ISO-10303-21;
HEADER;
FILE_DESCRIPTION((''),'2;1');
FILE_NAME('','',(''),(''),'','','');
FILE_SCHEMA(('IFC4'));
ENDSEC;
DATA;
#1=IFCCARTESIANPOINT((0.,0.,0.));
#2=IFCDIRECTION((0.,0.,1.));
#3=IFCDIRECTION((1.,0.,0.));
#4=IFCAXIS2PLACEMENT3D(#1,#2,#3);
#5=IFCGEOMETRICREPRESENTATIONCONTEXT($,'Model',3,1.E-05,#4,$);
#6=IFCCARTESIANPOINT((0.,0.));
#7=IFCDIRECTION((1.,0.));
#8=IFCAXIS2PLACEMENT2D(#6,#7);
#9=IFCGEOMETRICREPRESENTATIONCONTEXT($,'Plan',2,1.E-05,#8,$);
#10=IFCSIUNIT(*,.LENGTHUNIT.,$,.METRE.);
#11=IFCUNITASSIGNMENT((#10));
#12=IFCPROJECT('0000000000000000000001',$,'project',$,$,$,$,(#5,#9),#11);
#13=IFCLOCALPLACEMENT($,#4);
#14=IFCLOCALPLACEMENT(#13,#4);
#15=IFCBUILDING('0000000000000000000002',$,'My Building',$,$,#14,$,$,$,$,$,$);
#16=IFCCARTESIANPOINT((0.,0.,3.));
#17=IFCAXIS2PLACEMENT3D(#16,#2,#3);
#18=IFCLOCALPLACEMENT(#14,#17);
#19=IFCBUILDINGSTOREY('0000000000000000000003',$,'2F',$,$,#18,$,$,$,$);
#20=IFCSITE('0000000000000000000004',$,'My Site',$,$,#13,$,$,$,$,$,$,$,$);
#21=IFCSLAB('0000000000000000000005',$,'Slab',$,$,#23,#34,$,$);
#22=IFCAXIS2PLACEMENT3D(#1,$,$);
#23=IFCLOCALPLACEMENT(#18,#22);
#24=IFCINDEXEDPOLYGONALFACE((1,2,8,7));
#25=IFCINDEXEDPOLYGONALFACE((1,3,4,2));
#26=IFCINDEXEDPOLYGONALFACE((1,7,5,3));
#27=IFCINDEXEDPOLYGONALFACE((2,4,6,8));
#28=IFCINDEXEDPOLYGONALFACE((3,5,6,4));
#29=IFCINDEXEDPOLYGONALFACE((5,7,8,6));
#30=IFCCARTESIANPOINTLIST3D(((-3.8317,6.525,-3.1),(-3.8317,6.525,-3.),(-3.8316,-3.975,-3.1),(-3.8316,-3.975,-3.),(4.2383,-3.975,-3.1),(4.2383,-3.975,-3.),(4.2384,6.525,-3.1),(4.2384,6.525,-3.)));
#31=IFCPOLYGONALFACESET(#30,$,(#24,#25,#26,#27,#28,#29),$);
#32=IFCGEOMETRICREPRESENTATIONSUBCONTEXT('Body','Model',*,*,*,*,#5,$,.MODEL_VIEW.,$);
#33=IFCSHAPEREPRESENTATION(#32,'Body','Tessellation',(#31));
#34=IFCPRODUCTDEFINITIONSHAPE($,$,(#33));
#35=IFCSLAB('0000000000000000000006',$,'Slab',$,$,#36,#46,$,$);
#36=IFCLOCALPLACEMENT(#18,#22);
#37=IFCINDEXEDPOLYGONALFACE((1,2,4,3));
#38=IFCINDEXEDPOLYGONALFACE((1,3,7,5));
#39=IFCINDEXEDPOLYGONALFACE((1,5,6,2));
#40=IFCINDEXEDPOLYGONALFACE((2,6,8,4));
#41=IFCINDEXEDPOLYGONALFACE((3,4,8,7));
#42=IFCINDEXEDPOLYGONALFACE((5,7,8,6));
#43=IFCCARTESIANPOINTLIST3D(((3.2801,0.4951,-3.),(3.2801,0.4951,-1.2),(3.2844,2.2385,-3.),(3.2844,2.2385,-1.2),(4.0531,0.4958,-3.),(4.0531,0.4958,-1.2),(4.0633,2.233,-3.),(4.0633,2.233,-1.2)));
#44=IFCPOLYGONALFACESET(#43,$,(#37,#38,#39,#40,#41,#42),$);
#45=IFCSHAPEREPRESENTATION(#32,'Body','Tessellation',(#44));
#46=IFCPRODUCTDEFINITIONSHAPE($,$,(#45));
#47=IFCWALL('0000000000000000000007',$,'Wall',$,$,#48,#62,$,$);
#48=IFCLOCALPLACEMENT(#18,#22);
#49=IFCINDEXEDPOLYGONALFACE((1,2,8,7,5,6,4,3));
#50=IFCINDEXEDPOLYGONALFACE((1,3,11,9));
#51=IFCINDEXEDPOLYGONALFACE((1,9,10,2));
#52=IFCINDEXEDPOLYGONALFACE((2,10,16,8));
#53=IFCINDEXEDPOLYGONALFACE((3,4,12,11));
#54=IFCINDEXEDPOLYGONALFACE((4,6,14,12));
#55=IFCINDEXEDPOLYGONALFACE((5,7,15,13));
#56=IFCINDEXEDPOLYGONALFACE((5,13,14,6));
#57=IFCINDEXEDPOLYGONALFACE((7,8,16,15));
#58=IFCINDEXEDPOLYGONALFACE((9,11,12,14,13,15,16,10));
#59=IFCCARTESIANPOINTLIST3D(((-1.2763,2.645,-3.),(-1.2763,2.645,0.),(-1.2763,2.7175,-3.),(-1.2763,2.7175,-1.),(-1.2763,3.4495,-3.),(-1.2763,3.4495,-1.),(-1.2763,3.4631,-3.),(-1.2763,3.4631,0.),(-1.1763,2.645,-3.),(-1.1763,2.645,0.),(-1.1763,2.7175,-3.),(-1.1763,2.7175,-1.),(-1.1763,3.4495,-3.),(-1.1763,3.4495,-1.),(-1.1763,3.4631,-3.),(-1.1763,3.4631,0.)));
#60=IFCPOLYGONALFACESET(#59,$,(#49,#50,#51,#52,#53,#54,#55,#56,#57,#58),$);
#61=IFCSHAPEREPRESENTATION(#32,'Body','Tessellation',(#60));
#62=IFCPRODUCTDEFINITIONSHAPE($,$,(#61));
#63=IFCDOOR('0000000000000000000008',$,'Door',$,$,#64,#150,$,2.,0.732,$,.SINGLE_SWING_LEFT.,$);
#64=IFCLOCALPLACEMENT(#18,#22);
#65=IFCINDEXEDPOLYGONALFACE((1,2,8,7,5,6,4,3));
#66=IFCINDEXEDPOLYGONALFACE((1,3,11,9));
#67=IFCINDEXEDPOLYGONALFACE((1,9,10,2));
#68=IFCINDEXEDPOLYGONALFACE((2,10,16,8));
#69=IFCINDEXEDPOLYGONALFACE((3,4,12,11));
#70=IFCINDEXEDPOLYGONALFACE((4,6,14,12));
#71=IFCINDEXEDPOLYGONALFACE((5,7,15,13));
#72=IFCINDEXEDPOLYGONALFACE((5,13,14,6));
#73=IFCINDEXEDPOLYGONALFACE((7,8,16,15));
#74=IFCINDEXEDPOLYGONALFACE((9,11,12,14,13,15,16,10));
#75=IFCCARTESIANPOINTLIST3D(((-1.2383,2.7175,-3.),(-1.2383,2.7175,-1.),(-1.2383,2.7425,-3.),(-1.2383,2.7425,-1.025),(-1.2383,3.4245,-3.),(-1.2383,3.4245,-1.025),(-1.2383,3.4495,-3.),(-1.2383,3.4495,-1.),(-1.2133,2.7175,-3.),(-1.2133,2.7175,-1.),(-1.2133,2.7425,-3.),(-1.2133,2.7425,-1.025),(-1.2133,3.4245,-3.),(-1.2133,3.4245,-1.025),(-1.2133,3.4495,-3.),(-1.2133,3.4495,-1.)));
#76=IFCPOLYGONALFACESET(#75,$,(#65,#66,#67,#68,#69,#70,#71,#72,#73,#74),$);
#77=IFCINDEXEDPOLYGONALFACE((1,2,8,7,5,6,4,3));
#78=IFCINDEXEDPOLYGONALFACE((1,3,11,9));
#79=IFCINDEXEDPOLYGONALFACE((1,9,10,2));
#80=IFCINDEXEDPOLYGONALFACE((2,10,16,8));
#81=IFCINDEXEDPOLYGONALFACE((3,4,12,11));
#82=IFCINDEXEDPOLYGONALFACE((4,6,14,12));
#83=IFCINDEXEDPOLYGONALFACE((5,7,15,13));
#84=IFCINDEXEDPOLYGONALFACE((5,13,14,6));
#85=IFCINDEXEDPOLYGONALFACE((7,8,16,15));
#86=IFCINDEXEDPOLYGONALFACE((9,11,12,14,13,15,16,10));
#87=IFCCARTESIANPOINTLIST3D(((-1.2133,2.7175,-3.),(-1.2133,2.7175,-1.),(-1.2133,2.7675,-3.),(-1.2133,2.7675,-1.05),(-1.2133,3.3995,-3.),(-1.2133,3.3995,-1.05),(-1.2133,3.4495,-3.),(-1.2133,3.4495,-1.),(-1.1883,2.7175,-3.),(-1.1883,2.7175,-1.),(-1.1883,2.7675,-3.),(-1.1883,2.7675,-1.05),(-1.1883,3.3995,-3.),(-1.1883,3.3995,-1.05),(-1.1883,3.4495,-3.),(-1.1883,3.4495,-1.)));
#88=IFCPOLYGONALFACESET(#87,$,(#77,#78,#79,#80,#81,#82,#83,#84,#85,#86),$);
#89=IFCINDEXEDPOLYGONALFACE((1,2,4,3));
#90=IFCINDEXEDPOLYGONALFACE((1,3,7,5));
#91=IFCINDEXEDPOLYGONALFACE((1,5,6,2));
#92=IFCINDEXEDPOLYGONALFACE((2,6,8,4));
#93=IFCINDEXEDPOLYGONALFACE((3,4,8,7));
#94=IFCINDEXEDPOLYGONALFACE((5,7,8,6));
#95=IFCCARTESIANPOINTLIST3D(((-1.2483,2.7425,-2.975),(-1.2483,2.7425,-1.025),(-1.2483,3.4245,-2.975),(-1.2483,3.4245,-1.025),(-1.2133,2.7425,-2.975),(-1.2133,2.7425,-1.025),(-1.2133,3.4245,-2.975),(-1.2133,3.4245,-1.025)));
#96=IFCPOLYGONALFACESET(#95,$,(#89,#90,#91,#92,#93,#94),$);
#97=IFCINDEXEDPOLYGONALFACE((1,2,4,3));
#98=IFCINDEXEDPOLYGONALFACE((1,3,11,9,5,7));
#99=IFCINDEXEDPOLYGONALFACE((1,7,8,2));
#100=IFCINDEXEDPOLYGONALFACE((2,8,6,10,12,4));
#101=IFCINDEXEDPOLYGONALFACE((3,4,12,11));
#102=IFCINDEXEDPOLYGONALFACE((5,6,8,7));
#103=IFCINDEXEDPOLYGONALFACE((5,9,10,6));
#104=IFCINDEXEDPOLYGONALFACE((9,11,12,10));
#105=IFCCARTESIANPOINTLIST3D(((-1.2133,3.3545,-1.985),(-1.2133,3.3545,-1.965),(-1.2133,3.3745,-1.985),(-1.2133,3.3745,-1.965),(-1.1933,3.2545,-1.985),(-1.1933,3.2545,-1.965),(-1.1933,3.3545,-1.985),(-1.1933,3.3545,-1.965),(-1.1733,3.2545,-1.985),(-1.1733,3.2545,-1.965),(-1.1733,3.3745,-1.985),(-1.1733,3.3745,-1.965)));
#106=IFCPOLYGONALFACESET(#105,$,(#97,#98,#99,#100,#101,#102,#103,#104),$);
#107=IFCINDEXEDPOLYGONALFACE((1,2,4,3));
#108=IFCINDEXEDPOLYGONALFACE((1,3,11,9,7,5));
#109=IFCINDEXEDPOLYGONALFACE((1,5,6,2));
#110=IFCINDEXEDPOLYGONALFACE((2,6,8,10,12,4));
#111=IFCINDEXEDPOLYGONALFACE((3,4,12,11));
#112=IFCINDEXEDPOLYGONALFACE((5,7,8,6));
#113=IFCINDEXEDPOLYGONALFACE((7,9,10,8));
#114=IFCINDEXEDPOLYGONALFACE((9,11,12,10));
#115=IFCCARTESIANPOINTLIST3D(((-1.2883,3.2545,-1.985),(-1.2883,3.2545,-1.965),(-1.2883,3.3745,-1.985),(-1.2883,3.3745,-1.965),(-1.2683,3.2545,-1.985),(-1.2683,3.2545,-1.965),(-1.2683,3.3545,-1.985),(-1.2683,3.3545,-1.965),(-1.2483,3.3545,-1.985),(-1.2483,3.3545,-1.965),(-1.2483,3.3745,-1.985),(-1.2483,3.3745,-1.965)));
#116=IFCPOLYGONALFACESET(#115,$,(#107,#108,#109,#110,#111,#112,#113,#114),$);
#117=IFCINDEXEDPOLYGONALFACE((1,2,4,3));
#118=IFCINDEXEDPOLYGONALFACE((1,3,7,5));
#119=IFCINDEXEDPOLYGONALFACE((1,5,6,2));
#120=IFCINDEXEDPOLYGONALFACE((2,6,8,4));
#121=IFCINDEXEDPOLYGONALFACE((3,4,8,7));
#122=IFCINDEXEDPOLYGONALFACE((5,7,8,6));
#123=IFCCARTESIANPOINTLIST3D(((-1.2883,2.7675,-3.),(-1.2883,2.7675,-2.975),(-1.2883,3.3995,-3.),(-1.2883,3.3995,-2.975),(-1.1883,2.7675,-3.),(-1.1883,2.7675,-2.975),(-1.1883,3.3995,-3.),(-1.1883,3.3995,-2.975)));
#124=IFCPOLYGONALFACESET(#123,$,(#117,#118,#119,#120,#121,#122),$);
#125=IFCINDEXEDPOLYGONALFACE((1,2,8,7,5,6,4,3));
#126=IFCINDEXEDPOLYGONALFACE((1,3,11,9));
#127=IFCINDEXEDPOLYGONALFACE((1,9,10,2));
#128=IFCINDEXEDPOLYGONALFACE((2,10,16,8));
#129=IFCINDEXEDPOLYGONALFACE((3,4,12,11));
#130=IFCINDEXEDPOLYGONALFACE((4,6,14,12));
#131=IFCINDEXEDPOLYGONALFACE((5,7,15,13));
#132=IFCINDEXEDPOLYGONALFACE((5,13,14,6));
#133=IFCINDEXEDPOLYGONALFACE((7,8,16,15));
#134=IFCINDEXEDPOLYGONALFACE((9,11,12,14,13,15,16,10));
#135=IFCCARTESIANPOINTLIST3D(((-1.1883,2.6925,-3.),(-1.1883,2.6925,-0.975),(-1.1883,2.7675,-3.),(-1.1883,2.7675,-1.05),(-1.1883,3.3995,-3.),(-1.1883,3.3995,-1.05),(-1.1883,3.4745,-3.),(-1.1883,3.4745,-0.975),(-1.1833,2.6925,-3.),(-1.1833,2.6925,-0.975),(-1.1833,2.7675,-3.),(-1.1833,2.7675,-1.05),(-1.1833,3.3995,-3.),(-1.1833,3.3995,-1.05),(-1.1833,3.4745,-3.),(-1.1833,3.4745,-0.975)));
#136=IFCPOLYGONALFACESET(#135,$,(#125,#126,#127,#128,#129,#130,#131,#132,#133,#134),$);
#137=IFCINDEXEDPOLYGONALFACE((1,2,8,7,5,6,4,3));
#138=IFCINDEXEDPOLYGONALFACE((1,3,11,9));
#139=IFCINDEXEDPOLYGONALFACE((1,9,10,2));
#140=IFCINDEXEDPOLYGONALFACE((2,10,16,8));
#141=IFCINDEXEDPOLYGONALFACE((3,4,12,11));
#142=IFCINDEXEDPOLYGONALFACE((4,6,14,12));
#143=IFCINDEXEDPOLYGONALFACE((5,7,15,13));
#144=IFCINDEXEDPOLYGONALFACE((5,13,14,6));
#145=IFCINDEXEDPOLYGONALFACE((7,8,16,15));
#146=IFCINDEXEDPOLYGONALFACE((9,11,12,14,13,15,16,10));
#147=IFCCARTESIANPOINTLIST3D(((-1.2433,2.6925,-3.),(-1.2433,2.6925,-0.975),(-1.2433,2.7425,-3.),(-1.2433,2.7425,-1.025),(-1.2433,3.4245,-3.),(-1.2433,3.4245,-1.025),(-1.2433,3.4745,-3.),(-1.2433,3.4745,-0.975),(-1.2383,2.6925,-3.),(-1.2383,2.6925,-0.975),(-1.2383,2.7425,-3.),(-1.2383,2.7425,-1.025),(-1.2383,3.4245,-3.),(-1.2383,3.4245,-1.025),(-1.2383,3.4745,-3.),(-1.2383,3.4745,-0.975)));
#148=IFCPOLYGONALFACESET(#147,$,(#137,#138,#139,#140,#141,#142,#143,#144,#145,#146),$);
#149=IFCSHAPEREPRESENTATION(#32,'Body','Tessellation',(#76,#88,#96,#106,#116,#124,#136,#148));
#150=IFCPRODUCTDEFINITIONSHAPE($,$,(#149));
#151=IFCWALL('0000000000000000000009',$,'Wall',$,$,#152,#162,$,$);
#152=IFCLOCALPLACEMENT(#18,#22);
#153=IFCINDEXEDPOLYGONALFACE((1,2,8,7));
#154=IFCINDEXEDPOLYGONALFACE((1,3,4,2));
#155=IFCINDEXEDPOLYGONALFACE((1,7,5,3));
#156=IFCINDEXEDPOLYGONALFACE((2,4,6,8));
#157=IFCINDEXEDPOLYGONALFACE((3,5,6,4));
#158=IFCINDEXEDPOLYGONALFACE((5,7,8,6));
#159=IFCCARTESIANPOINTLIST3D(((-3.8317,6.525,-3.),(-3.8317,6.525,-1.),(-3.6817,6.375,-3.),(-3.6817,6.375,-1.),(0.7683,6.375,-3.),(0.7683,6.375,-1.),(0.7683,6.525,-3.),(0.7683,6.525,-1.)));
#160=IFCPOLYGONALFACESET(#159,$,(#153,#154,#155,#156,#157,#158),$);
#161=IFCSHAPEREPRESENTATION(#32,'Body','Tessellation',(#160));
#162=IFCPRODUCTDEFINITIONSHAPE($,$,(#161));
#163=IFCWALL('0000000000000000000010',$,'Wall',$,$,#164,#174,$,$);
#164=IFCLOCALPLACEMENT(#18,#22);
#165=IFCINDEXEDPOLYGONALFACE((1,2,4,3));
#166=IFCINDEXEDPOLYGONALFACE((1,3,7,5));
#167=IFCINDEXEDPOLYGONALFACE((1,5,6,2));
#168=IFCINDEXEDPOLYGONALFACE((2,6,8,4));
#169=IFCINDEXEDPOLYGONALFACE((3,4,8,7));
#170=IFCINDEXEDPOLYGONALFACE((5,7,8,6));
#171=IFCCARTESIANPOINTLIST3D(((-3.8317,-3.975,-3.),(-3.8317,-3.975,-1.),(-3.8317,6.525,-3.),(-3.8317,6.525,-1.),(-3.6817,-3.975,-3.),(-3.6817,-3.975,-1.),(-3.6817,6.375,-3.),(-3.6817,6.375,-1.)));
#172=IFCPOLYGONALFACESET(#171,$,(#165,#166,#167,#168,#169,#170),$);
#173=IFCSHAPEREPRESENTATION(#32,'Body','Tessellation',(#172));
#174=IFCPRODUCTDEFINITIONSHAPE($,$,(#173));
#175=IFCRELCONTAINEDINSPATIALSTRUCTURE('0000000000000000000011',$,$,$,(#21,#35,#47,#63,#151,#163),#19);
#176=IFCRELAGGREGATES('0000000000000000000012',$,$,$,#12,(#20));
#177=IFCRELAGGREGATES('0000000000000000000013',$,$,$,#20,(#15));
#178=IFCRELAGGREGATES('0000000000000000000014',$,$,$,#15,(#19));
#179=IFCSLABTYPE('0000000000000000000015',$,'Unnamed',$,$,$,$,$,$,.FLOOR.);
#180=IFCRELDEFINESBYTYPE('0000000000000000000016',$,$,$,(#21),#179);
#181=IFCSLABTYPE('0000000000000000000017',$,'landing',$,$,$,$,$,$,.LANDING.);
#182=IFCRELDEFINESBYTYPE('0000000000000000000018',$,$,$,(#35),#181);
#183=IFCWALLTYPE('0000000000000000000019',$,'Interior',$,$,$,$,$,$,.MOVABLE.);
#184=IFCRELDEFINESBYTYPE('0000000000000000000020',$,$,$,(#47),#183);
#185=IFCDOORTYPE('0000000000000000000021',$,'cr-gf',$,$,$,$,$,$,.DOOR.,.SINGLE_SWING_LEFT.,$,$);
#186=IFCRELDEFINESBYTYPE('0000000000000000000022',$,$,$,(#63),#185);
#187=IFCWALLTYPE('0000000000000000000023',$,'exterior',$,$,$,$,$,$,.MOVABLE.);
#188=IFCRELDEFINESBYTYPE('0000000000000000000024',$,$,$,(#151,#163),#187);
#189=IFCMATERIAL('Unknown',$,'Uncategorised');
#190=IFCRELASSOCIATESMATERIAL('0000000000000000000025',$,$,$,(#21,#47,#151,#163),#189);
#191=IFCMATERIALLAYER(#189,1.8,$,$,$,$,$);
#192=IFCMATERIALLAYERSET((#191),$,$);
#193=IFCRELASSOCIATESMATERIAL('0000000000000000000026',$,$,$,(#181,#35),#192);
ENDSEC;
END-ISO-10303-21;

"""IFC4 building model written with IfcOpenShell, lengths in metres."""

from ifc_helpers import new_model, entity, si_unit, frame, origin_with_axes, origin_2d_with_axis, place, context, subcontext, project, spatial, line, indexed_curve, outline, extrude, shape, source, transform, mapped, material, layer, layer_set, layer_usage, type_object, type_shapes, element, fill, save


model = new_model("IFC4")

# Units and contexts
model_context = context("Model", 3, precision=1e-05, world=origin_with_axes())
plan_context = context("Plan", 2, precision=1e-05, world=origin_2d_with_axis())
body_context_1 = subcontext(model_context, "Body", "Model", "MODEL_VIEW")
body_context_2 = subcontext(plan_context, "Body", "Plan", "PLAN_VIEW")
ifc_project = project(units=[si_unit("LENGTHUNIT", "METRE")], contexts=[model_context, plan_context])

# Site, building, storey
site_placement = place(None, origin_with_axes())
site = spatial("IfcSite", under=ifc_project, at=site_placement, Name="My Site")
building_placement = place(site_placement, origin_with_axes())
building = spatial("IfcBuilding", under=site, at=building_placement, Name="My Building")
storey_placement = place(building_placement, frame((0.0, 0.0, 3.0), z_axis=(0.0, 0.0, 1.0), x_axis=(1.0, 0.0, 0.0)))
storey = spatial("IfcBuildingStorey", under=building, at=storey_placement, Name="2F")

# Slabs
ifc_material = material(Name="Unknown", Category="Uncategorised")
slab_type_1 = type_object("IfcSlabType", Name="Unnamed", PredefinedType="FLOOR")
for number, where, z_axis, x_axis, name in (
    (1, (4.2384, 6.525, -3.0), (0.0, 0.0, 1.0), (1.0, 0.0, 0.0), "Slab"),
):
    element("IfcSlab", number, at=place(storey_placement, frame(where, z_axis=z_axis, x_axis=x_axis)), inside=storey, type_object=slab_type_1, material=ifc_material, Name=name, context=body_context_1, shape_type="SweptSolid", body=[
        extrude(outline(indexed_curve([(0.0, 0.0), (-8.07, 0.0), (-8.07, -10.5), (0.0, -10.5), (0.0, 0.0)])), frame((0.0, 0.0, -0.1), z_axis=(0.0, 0.0, 1.0), x_axis=(1.0, 0.0, 0.0)), (0.0, 0.0, 1.0), 0.1),
    ])
ifc_layer = layer(ifc_material, 1.8)
ifc_layer_set = layer_set([ifc_layer])
ifc_layer_usage = layer_usage(ifc_layer_set, "AXIS3", "POSITIVE", -0.25)
slab_type_2 = type_object("IfcSlabType", Name="landing", PredefinedType="LANDING", material=ifc_layer_set)
slab_placement = place(storey_placement, frame((3.2844, 2.2385, -2.75), z_axis=(0.0, 0.0, 1.0), x_axis=(1.0, 0.0, 0.0)))
element("IfcSlab", 2, at=slab_placement, inside=storey, type_object=slab_type_2, material=ifc_layer_usage, Name="Slab", context=body_context_1, shape_type="SweptSolid", body=[
    extrude(outline(indexed_curve([(0.779, -0.0055), (0.7688, -1.7427), (-0.0042, -1.7434), (0.0, 0.0), (0.779, -0.0055)])), frame((0.0, 0.0, -0.25), z_axis=(0.0, 0.0, 1.0), x_axis=(1.0, 0.0, 0.0)), (0.0, 0.0, 1.0), 1.8),
])

# Wall, opening, door
wall_type_1 = type_object("IfcWallType", Name="Interior", PredefinedType="MOVABLE")
wall_1_placement = place(storey_placement, frame((-1.2763, 3.4631, -3.0), z_axis=(0.0, 0.0, 1.0), x_axis=(0.0, -1.0, 0.0)))
wall_1 = element("IfcWall", 3, at=wall_1_placement, inside=storey, type_object=wall_type_1, material=ifc_material, Name="Wall", context=body_context_1, shape_type="SweptSolid", body=[
    extrude(outline(indexed_curve([(0.0, 0.0), (0.0, 0.1), (0.8182, 0.1), (0.8182, 0.0)], segments=[line(1, 2, 3, 4, 1)])), origin_with_axes(), (0.0, 0.0, 1.0), 3.0),
])
shared_shape_1 = source(origin_with_axes(), body_context_1, "Body", "SweptSolid", [
    extrude(outline(indexed_curve([(0.0, 0.0), (0.732, 0.0), (0.732, 2.0), (0.0, 2.0)], segments=[line(1, 2, 3, 4, 1)])), frame((0.0, -0.6, 0.0), z_axis=(0.0, -1.0, 0.0), x_axis=(1.0, 0.0, 0.0)), (0.0, 0.0, -1.0), 1.2),
])
opening_1_placement = place(wall_1_placement, frame((0.7456, 0.088, 0.0), z_axis=(0.0, 0.0, 1.0), x_axis=(-1.0, 0.0, 0.0)))
opening_1 = element("IfcOpeningElement", 4, at=opening_1_placement, cuts=wall_1, PredefinedType="OPENING", context=body_context_1, shape_type="MappedRepresentation", body=[
    mapped(shared_shape_1, transform((0.0, 0.0, 0.0), x_axis=(1.0, 0.0, 0.0), y_axis=(0.0, 1.0, 0.0), z_axis=(0.0, 0.0, 1.0), scale=1.0)),
])
door_type_1 = type_object("IfcDoorType", Name="cr-gf", OperationType="SINGLE_SWING_LEFT", PredefinedType="DOOR")
shared_shape_2 = source(origin_with_axes(), body_context_1, "Body", "SweptSolid", [
    extrude(outline(indexed_curve([(0.0, 0.0), (0.0, 2.0), (0.732, 2.0), (0.732, 0.0), (0.707, 0.0), (0.707, 1.975), (0.025, 1.975), (0.025, 0.0)], segments=[line(1, 2, 3, 4, 5, 6, 7, 8, 1)])), frame((0.0, 0.025, 0.0), z_axis=(0.0, -1.0, 0.0), x_axis=(1.0, 0.0, 0.0)), (0.0, 0.0, -1.0), 0.025),
    extrude(outline(indexed_curve([(0.0, 0.0), (0.0, 2.0), (0.732, 2.0), (0.732, 0.0), (0.682, 0.0), (0.682, 1.95), (0.05, 1.95), (0.05, 0.0)], segments=[line(1, 2, 3, 4, 5, 6, 7, 8, 1)])), frame((0.0, 0.0, 0.0), z_axis=(0.0, -1.0, 0.0), x_axis=(1.0, 0.0, 0.0)), (0.0, 0.0, -1.0), 0.025),
    extrude(outline(indexed_curve([(0.0, 0.0), (0.682, 0.0), (0.682, 0.035), (0.0, 0.035)], segments=[line(1, 2, 3, 4, 1)])), frame((0.025, 0.025, 0.025), z_axis=(0.0, 0.0, 1.0), x_axis=(1.0, 0.0, 0.0)), (0.0, 0.0, 1.0), 1.95),
    extrude(outline(indexed_curve([(0.0, 0.0), (0.0, -0.04), (-0.12, -0.04), (-0.12, -0.02), (-0.02, -0.02), (-0.02, 0.0)], segments=[line(1, 2, 3, 4, 5, 6, 1)])), frame((0.657, 0.025, 1.015), z_axis=(0.0, 0.0, 1.0), x_axis=(1.0, 0.0, 0.0)), (0.0, 0.0, 1.0), 0.02),
    extrude(outline(indexed_curve([(0.0, 0.0), (0.0, 0.04), (-0.12, 0.04), (-0.12, 0.02), (-0.02, 0.02), (-0.02, 0.0)], segments=[line(1, 2, 3, 4, 5, 6, 1)])), frame((0.657, 0.06, 1.015), z_axis=(0.0, 0.0, 1.0), x_axis=(1.0, 0.0, 0.0)), (0.0, 0.0, 1.0), 0.02),
    extrude(outline(indexed_curve([(0.0, 0.0), (0.632, 0.0), (0.632, 0.1), (0.0, 0.1)], segments=[line(1, 2, 3, 4, 1)])), frame((0.05, 0.0, 0.0), z_axis=(0.0, 0.0, 1.0), x_axis=(1.0, 0.0, 0.0)), (0.0, 0.0, 1.0), 0.025),
    extrude(outline(indexed_curve([(0.0, 0.0), (0.0, 2.025), (0.782, 2.025), (0.782, 0.0), (0.707, 0.0), (0.707, 1.95), (0.075, 1.95), (0.075, 0.0)], segments=[line(1, 2, 3, 4, 5, 6, 7, 8, 1)])), frame((-0.025, -0.005, 0.0), z_axis=(0.0, -1.0, 0.0), x_axis=(1.0, 0.0, 0.0)), (0.0, 0.0, -1.0), 0.005),
    extrude(outline(indexed_curve([(0.0, 0.0), (0.0, 2.025), (0.782, 2.025), (0.782, 0.0), (0.732, 0.0), (0.732, 1.975), (0.05, 1.975), (0.05, 0.0)], segments=[line(1, 2, 3, 4, 5, 6, 7, 8, 1)])), frame((-0.025, 0.05, 0.0), z_axis=(0.0, -1.0, 0.0), x_axis=(1.0, 0.0, 0.0)), (0.0, 0.0, -1.0), 0.005),
])
shared_shape_3 = source(origin_with_axes(), body_context_2, "Body", "Curve2D", [
    entity("IfcIndexedPolyCurve", entity("IfcCartesianPointList2D", [[0.0, 0.0], [0.0, 0.05], [0.025, 0.05], [0.025, 0.025], [0.05, 0.025], [0.05, 0.0]]), [entity("IfcLineIndex", [1, 2, 3, 4, 5, 6, 1])]),
    entity("IfcIndexedPolyCurve", entity("IfcCartesianPointList2D", [[0.732, 0.0], [0.732, 0.05], [0.707, 0.05], [0.707, 0.025], [0.682, 0.025], [0.682, 0.0]]), [entity("IfcLineIndex", [1, 2, 3, 4, 5, 6, 1])]),
    entity("IfcTrimmedCurve", entity("IfcEllipse", entity("IfcAxis2Placement2D", entity("IfcCartesianPoint", [0.06, 0.05]), entity("IfcDirection", [1.0, 0.0])), 0.647, 0.682), [entity("IfcCartesianPoint", [0.707, 0.05])], [entity("IfcCartesianPoint", [0.06, 0.732])], True, "CARTESIAN"),
    entity("IfcIndexedPolyCurve", entity("IfcCartesianPointList2D", [[0.025, 0.05], [0.06, 0.05], [0.06, 0.732], [0.025, 0.732]]), [entity("IfcLineIndex", [1, 2, 3, 4, 1])]),
])
type_shapes(door_type_1, [shared_shape_2, shared_shape_3])
door_1_placement = place(opening_1_placement, frame((0.0, 0.0, 0.0), z_axis=(0.0, 0.0, 1.0), x_axis=(1.0, 0.0, 0.0)))
door_1 = element("IfcDoor", 5, at=door_1_placement, inside=storey, type_object=door_type_1, Name="Door", OperationType="SINGLE_SWING_LEFT", OverallHeight=2.0, OverallWidth=0.732, shapes=[
    shape(body_context_1, "Body", "MappedRepresentation", [mapped(shared_shape_2, transform((0.0, 0.0, 0.0), x_axis=(1.0, 0.0, 0.0), y_axis=(0.0, 1.0, 0.0), z_axis=(0.0, 0.0, 1.0), scale=1.0))]),
    shape(body_context_2, "Body", "MappedRepresentation", [mapped(shared_shape_3, transform((0.0, 0.0, 0.0), x_axis=(1.0, 0.0, 0.0), y_axis=(0.0, 1.0, 0.0), z_axis=(0.0, 0.0, 1.0), scale=1.0))]),
])
fill(opening_1, door_1)

# Walls
wall_type_2 = type_object("IfcWallType", Name="exterior", PredefinedType="MOVABLE")
wall_2_placement = place(storey_placement, frame((0.7683, 6.525, -3.0), z_axis=(0.0, 0.0, 1.0), x_axis=(-1.0, 0.0, 0.0)))
element("IfcWall", 6, at=wall_2_placement, inside=storey, type_object=wall_type_2, material=ifc_material, Name="Wall", context=body_context_1, shape_type="SweptSolid", body=[
    extrude(outline(indexed_curve([(0.0, 0.0), (0.0, 0.15), (4.45, 0.15), (4.6, 0.0)], segments=[line(1, 2, 3, 4, 1)])), origin_with_axes(), (0.0, 0.0, 1.0), 2.0),
])
wall_3_placement = place(storey_placement, frame((-3.8317, 6.525, -3.0), z_axis=(0.0, 0.0, 1.0), x_axis=(0.0, -1.0, 0.0)))
element("IfcWall", 7, at=wall_3_placement, inside=storey, type_object=wall_type_2, material=ifc_material, Name="Wall", context=body_context_1, shape_type="SweptSolid", body=[
    extrude(outline(indexed_curve([(0.0, 0.0), (0.15, 0.15), (10.5, 0.15), (10.5, 0.0)], segments=[line(1, 2, 3, 4, 1)])), origin_with_axes(), (0.0, 0.0, 1.0), 2.0),
])

save(model, "model.ifc")
